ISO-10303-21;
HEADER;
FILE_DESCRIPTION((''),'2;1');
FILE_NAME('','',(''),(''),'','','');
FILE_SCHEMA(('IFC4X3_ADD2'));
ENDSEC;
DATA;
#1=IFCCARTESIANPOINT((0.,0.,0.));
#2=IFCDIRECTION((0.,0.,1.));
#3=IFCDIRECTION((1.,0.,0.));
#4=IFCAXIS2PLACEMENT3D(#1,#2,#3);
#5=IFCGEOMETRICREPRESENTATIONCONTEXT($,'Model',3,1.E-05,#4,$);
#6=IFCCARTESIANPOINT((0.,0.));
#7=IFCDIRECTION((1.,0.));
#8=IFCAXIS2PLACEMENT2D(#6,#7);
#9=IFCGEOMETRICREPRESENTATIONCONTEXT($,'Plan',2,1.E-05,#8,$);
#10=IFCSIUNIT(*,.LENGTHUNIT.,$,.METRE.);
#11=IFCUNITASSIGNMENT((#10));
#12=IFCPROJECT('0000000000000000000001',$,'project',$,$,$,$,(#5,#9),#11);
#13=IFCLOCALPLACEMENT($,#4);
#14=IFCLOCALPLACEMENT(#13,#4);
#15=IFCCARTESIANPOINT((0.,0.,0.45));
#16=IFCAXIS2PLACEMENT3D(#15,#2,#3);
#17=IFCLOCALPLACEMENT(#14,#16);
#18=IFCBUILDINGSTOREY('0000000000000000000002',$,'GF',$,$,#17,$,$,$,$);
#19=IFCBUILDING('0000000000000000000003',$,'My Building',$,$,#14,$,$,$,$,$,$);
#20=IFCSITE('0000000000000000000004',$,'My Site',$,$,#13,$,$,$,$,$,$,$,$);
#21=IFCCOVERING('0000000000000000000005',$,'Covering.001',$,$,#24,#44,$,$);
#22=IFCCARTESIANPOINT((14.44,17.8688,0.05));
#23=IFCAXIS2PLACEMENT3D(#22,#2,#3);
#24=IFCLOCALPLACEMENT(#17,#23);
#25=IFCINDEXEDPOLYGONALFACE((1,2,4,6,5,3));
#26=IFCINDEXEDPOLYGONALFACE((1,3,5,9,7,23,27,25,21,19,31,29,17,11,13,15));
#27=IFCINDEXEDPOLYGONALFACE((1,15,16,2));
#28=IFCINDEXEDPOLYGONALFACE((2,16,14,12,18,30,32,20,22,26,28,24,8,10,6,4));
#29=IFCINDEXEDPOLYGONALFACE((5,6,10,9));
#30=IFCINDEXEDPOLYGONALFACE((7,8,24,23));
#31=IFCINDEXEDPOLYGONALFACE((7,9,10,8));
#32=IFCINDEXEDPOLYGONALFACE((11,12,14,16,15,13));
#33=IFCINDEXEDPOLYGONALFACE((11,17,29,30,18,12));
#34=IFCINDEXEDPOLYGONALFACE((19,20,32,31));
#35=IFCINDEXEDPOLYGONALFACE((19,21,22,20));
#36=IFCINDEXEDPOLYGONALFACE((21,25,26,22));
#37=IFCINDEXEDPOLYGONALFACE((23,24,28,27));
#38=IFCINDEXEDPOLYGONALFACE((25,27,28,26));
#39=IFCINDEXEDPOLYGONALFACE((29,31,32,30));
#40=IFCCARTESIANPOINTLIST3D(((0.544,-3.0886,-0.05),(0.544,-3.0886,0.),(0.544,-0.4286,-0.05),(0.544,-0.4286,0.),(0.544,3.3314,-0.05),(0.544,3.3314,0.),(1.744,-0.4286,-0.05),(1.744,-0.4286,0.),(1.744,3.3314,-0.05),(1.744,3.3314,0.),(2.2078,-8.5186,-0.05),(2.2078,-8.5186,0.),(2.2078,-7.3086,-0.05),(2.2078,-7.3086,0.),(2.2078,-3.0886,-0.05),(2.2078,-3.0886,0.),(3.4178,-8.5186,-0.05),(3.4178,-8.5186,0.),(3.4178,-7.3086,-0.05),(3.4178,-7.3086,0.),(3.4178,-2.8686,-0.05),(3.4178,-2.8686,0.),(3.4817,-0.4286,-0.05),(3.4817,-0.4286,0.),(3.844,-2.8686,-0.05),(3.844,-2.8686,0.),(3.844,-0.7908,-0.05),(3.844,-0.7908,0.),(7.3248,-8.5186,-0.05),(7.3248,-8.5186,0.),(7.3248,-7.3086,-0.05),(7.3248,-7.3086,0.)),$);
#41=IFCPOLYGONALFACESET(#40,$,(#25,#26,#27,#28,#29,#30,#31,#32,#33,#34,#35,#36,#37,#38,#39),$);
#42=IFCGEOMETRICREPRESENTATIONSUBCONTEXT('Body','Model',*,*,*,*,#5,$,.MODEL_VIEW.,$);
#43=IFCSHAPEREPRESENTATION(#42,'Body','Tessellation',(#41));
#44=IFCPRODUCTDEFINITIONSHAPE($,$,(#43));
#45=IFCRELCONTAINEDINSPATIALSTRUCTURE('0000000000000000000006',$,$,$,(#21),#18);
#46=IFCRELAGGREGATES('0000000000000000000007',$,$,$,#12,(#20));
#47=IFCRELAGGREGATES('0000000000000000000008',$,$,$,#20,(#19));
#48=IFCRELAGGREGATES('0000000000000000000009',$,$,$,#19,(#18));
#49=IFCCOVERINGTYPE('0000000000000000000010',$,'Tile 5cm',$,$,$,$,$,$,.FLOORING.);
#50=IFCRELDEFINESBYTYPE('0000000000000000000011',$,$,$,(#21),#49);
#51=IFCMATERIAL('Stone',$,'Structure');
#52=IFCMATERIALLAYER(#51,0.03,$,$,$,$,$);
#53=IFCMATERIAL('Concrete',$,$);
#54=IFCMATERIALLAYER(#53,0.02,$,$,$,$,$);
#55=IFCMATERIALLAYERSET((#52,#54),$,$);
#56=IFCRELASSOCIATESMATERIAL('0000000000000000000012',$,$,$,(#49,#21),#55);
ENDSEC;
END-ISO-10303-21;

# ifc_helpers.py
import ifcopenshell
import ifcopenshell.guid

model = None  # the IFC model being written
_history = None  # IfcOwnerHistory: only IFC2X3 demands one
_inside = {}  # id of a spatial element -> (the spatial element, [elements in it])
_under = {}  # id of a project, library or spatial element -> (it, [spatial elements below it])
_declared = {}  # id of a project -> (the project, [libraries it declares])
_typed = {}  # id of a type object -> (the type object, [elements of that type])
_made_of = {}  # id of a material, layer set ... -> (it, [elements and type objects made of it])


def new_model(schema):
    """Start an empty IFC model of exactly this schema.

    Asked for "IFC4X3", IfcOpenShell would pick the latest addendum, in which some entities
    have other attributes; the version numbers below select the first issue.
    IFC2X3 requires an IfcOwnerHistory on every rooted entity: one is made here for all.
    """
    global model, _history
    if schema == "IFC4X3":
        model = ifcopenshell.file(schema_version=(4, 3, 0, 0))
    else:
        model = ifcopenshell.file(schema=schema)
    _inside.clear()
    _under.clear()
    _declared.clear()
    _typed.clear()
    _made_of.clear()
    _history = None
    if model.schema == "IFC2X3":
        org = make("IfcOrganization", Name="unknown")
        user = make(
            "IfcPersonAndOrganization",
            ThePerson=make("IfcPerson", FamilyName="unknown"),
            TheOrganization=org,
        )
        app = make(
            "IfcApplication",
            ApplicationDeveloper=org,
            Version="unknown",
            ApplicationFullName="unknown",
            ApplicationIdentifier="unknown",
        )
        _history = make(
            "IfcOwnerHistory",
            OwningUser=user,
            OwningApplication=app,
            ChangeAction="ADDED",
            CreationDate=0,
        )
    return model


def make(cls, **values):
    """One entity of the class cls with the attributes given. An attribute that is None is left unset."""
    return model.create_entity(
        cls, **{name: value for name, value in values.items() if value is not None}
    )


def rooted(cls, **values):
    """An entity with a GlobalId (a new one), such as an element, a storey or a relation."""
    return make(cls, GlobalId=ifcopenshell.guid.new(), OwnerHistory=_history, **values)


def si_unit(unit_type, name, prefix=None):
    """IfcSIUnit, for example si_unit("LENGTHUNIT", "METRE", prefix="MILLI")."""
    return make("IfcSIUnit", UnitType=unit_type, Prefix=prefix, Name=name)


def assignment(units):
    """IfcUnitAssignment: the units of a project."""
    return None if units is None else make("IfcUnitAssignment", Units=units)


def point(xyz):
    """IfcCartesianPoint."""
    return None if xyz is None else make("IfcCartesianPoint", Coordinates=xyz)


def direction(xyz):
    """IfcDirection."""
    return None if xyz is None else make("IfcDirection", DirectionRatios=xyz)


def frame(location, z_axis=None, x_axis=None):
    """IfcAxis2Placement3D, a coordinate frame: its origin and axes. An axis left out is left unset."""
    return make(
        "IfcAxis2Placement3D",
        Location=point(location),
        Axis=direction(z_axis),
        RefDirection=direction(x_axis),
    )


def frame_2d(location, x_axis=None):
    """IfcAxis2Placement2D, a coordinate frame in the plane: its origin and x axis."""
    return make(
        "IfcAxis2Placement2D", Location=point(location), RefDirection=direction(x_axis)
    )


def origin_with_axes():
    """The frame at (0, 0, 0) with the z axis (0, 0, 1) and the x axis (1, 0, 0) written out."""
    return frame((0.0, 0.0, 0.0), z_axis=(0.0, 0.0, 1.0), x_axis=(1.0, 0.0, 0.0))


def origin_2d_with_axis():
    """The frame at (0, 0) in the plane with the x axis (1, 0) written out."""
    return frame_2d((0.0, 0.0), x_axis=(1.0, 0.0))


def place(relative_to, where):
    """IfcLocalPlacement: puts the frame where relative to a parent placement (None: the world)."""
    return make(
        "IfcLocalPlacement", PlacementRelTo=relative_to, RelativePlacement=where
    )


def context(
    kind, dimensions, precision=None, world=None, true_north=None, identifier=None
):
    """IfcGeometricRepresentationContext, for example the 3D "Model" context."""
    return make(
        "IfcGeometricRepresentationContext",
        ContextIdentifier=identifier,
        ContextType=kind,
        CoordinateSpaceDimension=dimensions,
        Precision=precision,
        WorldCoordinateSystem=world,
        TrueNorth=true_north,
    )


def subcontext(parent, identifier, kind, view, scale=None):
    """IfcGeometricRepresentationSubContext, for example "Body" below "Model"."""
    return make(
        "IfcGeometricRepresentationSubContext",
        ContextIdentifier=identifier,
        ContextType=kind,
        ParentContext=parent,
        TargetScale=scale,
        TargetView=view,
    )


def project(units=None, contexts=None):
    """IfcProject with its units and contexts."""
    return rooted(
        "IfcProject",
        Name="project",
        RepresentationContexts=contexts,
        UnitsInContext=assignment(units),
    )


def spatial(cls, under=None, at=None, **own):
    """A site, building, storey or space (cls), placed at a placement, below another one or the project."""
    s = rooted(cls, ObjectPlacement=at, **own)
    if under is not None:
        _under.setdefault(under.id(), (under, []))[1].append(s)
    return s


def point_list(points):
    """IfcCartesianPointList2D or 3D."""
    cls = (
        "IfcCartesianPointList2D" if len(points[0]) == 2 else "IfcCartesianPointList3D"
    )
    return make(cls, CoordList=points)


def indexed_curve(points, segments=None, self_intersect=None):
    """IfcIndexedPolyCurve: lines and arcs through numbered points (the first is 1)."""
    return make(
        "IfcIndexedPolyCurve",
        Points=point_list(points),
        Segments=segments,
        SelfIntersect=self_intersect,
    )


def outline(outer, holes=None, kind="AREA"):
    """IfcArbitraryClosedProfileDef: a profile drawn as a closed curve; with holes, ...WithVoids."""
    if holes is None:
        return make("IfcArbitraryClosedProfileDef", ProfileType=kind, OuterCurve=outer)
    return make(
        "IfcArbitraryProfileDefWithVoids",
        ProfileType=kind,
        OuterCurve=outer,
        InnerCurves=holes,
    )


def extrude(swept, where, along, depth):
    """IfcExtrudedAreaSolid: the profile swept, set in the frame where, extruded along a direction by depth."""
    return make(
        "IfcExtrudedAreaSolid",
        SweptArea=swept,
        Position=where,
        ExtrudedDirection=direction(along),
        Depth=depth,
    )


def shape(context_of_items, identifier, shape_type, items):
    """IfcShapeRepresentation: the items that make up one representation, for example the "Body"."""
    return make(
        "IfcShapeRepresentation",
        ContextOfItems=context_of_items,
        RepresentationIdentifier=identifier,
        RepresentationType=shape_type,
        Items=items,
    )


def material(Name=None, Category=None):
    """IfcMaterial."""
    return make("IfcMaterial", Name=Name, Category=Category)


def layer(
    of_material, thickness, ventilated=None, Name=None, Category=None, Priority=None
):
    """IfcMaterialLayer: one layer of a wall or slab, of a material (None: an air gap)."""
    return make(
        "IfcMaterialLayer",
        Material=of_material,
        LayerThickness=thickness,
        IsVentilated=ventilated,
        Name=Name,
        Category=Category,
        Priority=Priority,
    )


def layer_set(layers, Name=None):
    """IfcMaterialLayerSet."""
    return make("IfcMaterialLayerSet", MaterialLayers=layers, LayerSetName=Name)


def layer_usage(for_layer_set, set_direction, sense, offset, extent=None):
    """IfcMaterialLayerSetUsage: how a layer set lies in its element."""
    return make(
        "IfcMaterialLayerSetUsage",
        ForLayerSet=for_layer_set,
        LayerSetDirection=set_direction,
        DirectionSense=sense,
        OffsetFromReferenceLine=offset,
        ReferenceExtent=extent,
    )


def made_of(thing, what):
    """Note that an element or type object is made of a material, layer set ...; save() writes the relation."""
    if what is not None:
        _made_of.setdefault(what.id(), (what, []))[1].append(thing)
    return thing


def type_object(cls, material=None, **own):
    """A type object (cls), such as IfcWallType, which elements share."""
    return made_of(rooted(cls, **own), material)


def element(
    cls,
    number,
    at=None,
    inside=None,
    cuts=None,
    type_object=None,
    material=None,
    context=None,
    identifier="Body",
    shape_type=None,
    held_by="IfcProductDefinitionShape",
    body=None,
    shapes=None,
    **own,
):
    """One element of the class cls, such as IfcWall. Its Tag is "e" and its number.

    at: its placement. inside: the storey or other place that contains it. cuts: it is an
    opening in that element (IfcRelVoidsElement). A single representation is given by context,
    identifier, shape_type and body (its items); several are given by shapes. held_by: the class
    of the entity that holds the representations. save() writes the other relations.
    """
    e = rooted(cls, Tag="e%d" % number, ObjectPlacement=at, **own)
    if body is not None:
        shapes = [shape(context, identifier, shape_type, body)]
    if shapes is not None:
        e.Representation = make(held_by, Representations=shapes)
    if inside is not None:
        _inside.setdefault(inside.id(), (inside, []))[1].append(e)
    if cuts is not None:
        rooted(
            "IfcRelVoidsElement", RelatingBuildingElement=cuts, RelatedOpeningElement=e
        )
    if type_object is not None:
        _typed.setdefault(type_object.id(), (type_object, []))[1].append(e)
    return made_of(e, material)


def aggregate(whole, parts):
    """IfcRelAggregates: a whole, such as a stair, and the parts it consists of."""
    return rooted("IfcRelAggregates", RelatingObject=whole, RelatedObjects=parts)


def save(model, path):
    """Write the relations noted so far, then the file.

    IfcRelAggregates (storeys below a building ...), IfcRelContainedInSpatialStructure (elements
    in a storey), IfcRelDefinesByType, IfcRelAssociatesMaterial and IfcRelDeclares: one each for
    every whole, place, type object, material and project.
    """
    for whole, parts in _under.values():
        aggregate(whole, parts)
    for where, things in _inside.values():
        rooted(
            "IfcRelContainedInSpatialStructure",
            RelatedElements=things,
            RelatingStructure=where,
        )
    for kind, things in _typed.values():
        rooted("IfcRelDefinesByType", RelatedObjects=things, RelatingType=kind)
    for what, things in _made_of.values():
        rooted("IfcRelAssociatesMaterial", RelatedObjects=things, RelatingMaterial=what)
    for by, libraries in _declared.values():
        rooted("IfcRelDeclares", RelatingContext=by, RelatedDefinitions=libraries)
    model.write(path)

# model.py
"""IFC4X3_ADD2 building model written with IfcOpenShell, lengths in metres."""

from ifc_helpers import new_model, si_unit, frame, origin_with_axes, origin_2d_with_axis, place, context, subcontext, project, spatial, indexed_curve, outline, extrude, material, layer, layer_set, layer_usage, type_object, element, save


model = new_model("IFC4X3_ADD2")

# Units and contexts
model_context = context("Model", 3, precision=1e-05, world=origin_with_axes())
plan_context = context("Plan", 2, precision=1e-05, world=origin_2d_with_axis())
body_context_1 = subcontext(model_context, "Body", "Model", "MODEL_VIEW")
ifc_project = project(units=[si_unit("LENGTHUNIT", "METRE")], contexts=[model_context, plan_context])

# Site, building, storey
site_placement = place(None, origin_with_axes())
site = spatial("IfcSite", under=ifc_project, at=site_placement, Name="My Site")
building_placement = place(site_placement, origin_with_axes())
building = spatial("IfcBuilding", under=site, at=building_placement, Name="My Building")
storey_placement = place(building_placement, frame((0.0, 0.0, 0.45), z_axis=(0.0, 0.0, 1.0), x_axis=(1.0, 0.0, 0.0)))
storey = spatial("IfcBuildingStorey", under=building, at=storey_placement, Name="GF")

# Covering
ifc_material_1 = material(Name="Stone", Category="Structure")
ifc_layer_1 = layer(ifc_material_1, 0.03)
ifc_material_2 = material(Name="Concrete")
ifc_layer_2 = layer(ifc_material_2, 0.02)
ifc_layer_set = layer_set([ifc_layer_1, ifc_layer_2])
ifc_layer_usage = layer_usage(ifc_layer_set, "AXIS3", "POSITIVE", -0.05)
covering_type = type_object("IfcCoveringType", Name="Tile 5cm", PredefinedType="FLOORING", material=ifc_layer_set)
covering_placement = place(storey_placement, frame((14.44, 17.8688, 0.05), z_axis=(0.0, 0.0, 1.0), x_axis=(1.0, 0.0, 0.0)))
element("IfcCovering", 1, at=covering_placement, inside=storey, type_object=covering_type, material=ifc_layer_usage, Name="Covering.001", context=body_context_1, shape_type="SweptSolid", body=[
    extrude(outline(indexed_curve([(0.544, -0.4286), (0.544, 3.3314), (1.744, 3.3314), (1.744, -0.4286), (3.4817, -0.4286), (3.844, -0.7908), (3.844, -2.8686), (3.4178, -2.8686), (3.4178, -7.3086), (7.3248, -7.3086), (7.3248, -8.5186), (3.4178, -8.5186), (2.2078, -8.5186), (2.2078, -7.3086), (2.2078, -3.0886), (0.544, -3.0886), (0.544, -0.4286)])), frame((0.0, 0.0, -0.05), z_axis=(0.0, 0.0, 1.0), x_axis=(1.0, 0.0, 0.0)), (0.0, 0.0, 1.0), 0.05),
])

save(model, "model.ifc")
